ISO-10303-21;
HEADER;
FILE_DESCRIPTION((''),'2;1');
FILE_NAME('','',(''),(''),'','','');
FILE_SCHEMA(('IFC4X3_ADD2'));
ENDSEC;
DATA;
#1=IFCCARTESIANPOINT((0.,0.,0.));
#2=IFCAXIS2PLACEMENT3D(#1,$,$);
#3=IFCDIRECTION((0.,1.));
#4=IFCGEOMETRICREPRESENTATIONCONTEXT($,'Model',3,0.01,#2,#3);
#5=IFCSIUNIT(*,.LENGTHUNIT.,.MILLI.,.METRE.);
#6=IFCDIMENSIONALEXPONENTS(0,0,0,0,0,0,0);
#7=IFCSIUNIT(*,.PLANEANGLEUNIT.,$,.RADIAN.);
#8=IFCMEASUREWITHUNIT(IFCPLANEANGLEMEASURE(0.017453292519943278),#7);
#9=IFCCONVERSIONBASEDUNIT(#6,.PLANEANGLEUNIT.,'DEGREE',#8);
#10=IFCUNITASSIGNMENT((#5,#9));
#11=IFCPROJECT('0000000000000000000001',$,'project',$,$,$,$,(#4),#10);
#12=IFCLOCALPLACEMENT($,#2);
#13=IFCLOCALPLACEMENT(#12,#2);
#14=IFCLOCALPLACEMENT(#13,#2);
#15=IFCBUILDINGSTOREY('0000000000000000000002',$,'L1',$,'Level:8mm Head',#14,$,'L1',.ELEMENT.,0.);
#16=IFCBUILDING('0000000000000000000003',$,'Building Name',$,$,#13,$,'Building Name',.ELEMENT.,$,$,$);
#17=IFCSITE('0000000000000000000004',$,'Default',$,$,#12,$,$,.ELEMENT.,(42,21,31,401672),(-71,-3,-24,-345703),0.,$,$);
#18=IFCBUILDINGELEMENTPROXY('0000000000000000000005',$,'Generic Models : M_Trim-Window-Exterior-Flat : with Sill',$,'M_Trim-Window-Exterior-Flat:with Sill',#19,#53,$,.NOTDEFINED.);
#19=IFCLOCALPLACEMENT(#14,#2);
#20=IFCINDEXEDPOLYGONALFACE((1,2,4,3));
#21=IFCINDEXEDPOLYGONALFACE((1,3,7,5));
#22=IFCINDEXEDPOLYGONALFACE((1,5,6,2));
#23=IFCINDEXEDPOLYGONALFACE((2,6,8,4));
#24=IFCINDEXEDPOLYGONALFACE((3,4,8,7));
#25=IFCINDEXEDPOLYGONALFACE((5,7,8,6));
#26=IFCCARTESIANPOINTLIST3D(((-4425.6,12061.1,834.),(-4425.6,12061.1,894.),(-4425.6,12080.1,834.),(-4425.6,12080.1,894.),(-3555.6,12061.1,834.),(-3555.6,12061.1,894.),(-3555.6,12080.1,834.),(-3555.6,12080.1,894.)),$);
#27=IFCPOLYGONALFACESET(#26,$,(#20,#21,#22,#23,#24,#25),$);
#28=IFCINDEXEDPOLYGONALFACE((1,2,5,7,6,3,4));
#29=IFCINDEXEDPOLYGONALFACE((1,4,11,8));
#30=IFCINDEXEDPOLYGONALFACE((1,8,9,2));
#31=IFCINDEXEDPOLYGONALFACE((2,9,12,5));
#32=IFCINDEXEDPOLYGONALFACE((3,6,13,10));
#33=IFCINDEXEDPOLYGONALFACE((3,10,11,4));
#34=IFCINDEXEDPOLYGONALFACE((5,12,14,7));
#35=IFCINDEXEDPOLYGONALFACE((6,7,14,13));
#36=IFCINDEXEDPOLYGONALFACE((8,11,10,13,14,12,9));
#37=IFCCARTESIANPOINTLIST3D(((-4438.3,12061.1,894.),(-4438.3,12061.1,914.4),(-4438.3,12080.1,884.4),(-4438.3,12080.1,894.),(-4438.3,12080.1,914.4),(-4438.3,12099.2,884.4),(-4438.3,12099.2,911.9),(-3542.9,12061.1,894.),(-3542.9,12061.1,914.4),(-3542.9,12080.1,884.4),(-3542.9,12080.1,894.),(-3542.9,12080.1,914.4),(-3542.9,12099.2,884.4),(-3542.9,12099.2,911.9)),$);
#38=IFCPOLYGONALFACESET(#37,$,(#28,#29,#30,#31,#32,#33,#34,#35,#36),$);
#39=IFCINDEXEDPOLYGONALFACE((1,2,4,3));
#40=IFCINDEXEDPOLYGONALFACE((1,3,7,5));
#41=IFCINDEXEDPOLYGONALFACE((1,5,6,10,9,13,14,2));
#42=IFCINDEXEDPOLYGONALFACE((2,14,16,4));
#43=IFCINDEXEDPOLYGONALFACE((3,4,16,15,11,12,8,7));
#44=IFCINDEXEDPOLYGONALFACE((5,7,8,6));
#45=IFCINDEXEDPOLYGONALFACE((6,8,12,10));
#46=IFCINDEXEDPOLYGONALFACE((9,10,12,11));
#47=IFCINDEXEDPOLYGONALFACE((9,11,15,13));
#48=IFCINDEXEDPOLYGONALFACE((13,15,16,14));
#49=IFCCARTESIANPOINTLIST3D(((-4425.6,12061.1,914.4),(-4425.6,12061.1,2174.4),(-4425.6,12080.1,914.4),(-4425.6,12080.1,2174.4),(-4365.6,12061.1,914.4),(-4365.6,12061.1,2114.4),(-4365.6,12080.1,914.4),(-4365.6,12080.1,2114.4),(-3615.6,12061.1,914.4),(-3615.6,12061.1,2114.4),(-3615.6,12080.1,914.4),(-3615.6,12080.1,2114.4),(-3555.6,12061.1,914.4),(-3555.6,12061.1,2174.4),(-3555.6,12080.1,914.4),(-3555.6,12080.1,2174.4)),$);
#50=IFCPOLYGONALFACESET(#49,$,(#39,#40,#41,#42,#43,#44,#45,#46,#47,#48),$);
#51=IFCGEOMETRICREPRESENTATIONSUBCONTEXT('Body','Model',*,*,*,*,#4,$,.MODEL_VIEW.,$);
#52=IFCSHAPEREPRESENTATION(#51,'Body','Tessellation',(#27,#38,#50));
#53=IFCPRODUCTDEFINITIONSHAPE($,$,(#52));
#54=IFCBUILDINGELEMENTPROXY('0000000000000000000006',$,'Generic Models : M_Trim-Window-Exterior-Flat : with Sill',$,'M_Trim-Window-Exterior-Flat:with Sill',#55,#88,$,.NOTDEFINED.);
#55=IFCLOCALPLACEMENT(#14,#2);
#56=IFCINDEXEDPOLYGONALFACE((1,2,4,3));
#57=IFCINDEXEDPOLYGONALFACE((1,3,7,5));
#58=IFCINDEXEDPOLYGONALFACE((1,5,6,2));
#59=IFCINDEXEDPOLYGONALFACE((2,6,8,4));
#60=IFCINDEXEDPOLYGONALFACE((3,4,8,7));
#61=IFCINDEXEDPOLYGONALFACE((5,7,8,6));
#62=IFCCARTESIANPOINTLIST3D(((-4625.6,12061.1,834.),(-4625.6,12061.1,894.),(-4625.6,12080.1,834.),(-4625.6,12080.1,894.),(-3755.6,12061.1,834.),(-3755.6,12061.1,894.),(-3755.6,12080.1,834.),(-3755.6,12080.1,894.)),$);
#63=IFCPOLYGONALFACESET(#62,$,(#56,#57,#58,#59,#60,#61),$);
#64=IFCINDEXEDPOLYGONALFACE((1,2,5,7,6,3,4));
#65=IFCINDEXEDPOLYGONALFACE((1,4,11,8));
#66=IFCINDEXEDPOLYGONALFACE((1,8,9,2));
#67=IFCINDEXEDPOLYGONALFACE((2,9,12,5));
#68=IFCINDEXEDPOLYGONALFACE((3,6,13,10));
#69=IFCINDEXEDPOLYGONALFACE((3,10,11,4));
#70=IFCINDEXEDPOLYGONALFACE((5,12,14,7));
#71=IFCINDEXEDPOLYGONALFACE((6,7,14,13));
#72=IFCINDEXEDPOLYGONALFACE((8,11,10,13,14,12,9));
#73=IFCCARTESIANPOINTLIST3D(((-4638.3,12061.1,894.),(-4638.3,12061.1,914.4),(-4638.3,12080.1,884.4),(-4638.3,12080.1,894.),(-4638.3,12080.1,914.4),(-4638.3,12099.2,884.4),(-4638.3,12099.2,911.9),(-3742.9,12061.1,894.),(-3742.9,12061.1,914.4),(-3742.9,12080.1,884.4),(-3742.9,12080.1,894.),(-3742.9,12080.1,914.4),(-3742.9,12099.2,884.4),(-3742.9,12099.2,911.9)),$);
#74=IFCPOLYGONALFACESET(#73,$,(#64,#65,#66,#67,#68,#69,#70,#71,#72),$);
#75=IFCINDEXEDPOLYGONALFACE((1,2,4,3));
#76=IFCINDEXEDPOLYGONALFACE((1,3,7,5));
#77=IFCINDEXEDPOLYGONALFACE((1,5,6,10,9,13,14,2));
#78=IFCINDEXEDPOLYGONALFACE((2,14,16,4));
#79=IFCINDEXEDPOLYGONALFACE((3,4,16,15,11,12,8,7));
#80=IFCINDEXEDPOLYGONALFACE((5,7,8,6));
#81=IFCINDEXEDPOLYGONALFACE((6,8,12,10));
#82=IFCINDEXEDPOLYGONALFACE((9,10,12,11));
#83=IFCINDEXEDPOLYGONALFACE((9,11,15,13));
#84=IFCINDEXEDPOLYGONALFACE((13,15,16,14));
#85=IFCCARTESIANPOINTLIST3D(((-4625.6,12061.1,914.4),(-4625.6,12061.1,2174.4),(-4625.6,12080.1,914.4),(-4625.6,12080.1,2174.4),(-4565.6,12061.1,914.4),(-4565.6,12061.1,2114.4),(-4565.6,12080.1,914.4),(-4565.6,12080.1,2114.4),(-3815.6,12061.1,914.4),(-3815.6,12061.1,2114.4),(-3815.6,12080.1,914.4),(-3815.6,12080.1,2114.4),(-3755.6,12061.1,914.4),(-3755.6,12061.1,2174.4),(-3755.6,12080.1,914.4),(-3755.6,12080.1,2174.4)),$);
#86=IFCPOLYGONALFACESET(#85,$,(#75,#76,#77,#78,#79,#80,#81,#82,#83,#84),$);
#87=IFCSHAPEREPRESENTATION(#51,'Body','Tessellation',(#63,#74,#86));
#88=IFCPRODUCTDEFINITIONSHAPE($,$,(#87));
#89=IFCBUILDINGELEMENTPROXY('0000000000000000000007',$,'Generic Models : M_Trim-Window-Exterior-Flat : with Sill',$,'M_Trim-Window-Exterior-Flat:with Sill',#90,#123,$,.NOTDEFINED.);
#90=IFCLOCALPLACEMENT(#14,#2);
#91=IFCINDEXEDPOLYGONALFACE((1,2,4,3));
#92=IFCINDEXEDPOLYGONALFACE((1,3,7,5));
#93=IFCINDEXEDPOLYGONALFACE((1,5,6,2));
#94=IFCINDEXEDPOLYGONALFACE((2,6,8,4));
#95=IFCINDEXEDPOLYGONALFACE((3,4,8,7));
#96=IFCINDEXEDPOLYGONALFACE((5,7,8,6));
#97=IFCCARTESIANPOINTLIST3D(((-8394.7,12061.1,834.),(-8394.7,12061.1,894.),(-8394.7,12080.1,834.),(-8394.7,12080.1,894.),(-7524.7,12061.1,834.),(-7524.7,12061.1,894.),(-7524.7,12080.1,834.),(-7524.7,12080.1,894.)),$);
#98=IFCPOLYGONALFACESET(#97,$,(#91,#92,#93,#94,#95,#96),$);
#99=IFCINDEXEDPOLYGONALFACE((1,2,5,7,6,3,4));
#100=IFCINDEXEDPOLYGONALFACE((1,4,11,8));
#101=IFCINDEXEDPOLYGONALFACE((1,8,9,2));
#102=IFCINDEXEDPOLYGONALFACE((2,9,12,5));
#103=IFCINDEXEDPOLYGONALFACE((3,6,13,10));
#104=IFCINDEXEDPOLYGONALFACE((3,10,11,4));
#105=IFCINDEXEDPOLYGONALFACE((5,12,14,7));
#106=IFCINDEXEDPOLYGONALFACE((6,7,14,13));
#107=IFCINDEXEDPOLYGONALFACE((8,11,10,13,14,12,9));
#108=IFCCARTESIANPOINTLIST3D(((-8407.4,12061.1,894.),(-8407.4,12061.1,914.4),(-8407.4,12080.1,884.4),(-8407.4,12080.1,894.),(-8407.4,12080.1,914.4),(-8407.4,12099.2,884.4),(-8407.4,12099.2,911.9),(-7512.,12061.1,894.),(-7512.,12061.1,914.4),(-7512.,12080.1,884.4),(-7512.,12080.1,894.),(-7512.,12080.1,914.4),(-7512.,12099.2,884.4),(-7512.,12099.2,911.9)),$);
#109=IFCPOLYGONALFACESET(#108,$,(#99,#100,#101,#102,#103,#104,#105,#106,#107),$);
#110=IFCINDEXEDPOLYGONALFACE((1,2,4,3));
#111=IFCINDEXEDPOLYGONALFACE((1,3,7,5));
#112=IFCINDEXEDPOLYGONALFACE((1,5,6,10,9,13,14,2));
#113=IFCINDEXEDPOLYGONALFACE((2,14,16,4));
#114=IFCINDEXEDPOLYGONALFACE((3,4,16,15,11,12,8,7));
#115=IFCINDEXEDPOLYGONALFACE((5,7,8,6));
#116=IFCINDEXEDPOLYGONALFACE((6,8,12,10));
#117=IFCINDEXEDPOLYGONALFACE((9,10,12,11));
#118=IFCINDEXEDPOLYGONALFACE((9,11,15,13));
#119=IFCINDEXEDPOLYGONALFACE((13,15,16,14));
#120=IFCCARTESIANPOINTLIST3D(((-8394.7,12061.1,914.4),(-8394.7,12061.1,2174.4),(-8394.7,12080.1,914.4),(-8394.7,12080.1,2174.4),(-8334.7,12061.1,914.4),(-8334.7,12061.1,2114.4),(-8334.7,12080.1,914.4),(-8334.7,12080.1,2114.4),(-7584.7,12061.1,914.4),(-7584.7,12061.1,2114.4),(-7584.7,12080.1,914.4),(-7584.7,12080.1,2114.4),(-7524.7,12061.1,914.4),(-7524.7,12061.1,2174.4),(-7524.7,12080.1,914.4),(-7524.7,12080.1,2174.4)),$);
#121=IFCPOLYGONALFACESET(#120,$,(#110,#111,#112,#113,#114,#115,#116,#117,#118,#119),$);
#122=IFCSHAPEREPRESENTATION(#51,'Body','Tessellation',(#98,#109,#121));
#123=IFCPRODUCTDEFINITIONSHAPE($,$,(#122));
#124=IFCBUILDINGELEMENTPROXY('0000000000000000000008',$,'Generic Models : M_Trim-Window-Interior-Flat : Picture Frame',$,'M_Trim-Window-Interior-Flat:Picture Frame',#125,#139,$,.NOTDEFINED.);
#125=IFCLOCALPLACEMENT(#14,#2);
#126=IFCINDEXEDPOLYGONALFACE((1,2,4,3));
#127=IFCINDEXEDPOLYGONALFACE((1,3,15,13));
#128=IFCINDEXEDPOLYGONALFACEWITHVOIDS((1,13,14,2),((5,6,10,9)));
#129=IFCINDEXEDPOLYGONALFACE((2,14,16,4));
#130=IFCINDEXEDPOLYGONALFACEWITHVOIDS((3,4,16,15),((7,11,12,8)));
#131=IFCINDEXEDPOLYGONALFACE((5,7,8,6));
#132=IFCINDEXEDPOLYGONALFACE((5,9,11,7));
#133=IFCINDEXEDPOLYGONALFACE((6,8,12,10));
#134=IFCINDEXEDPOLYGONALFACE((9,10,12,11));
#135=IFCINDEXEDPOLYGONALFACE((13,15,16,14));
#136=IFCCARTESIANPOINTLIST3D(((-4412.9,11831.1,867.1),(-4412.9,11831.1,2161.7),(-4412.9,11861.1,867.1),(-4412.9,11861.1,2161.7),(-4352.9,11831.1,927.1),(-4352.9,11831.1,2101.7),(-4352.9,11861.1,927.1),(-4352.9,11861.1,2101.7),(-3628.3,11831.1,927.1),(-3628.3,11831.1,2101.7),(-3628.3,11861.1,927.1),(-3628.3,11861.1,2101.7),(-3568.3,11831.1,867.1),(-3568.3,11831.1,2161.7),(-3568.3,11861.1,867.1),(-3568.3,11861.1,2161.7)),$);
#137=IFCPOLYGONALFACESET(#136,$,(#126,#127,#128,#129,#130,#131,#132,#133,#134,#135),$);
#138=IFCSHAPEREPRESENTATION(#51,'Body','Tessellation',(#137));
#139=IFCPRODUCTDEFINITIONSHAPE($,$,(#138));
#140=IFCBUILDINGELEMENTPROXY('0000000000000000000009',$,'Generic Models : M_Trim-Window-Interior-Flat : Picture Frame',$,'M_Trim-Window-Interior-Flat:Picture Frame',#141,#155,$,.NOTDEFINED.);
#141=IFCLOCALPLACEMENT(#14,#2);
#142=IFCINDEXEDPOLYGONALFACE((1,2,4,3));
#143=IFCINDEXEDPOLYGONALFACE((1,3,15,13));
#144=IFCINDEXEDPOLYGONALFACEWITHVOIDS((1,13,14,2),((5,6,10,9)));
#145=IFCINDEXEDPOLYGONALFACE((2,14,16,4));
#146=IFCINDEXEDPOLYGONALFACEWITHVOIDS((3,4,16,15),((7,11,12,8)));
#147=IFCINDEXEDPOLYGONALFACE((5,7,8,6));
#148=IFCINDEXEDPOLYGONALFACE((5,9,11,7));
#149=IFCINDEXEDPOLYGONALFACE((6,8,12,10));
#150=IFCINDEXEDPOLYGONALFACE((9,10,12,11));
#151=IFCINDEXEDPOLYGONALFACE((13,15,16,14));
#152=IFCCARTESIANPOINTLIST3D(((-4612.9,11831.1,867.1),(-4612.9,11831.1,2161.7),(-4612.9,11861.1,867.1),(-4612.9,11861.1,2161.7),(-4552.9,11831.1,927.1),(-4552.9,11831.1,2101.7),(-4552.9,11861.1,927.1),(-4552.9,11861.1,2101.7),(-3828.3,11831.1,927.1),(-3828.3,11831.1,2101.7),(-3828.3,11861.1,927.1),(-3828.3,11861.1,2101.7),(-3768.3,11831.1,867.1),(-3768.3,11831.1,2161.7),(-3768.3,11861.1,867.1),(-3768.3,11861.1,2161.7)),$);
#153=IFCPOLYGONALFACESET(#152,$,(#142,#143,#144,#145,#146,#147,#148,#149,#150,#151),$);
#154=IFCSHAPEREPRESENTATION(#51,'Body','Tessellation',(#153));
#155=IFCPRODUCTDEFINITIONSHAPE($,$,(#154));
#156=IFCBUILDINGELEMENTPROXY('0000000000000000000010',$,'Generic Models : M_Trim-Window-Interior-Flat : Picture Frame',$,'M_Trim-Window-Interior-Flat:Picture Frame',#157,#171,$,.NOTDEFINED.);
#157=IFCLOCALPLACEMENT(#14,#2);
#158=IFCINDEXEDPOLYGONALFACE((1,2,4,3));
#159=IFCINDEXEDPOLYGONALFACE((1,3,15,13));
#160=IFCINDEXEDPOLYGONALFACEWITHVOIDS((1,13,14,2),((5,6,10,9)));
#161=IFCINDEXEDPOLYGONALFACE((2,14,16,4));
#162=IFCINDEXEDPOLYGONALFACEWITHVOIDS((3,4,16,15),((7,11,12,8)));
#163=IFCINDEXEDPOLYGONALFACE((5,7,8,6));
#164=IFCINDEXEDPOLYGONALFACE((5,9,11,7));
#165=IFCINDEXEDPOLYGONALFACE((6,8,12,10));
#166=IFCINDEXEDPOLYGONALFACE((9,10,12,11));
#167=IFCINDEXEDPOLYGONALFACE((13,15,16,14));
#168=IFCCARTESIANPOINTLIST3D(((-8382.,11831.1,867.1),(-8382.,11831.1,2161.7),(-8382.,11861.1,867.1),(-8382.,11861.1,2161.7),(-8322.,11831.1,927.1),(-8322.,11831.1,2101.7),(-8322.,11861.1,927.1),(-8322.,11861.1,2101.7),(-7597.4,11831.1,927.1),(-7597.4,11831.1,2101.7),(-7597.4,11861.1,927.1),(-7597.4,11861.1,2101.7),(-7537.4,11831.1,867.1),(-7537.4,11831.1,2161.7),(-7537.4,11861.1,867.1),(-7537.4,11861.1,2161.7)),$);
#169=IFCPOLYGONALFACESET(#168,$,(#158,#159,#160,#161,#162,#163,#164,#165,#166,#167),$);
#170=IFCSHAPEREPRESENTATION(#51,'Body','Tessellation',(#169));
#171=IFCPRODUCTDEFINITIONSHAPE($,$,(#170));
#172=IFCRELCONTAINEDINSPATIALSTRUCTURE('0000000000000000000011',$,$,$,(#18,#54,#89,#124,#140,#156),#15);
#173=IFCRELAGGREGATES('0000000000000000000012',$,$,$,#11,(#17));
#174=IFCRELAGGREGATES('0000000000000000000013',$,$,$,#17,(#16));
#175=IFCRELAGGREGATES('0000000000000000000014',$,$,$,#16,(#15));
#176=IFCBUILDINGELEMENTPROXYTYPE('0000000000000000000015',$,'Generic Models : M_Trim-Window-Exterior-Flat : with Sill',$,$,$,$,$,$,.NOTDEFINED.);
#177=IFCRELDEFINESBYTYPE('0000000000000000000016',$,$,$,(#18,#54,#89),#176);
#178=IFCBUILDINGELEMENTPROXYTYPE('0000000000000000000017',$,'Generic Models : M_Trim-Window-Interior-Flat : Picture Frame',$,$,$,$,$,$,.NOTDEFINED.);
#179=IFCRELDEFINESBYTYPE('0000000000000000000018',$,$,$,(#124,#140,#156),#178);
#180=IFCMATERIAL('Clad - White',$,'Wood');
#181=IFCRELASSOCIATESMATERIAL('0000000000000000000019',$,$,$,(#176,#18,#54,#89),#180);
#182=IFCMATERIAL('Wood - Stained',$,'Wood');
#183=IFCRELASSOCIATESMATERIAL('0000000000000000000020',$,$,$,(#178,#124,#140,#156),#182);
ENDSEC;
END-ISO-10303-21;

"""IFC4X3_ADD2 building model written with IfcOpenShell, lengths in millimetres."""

from ifc_helpers import new_model, entity, si_unit, converted_unit, direction, frame, frame_2d, origin, place, context, subcontext, project, spatial, polyline, rectangle, outline, extrude, source, transform, mapped, material, type_object, type_shapes, element, save


model = new_model("IFC4X3_ADD2")

# Units and contexts
model_context = context("Model", 3, precision=0.01, world=origin(), true_north=direction((0.0, 1.0)))
body_context = subcontext(model_context, "Body", "Model", "MODEL_VIEW")
ifc_project = project(units=[si_unit("LENGTHUNIT", "METRE", prefix="MILLI"), converted_unit("PLANEANGLEUNIT", "DEGREE", entity("IfcPlaneAngleMeasure", 0.017453292519943278), si_unit("PLANEANGLEUNIT", "RADIAN"), dimensions=[0, 0, 0, 0, 0, 0, 0])], contexts=[model_context])

# Site, building, storey
site_placement = place(None, origin())
site = spatial("IfcSite", under=ifc_project, at=site_placement, Name="Default", CompositionType="ELEMENT", RefLatitude=(42, 21, 31, 401672), RefLongitude=(-71, -3, -24, -345703), RefElevation=0.0)
building_placement = place(site_placement, origin())
building = spatial("IfcBuilding", under=site, at=building_placement, Name="Building Name", LongName="Building Name", CompositionType="ELEMENT")
storey_placement = place(building_placement, origin())
storey = spatial("IfcBuildingStorey", under=building, at=storey_placement, Name="L1", ObjectType="Level:8mm Head", LongName="L1", CompositionType="ELEMENT", Elevation=0.0)

# Shared definitions
ifc_material_1 = material(Name="Wood - Stained", Category="Wood")

# Building element proxies
ifc_material_2 = material(Name="Clad - White", Category="Wood")
building_element_proxy_type_1 = type_object("IfcBuildingElementProxyType", Name="Generic Models : M_Trim-Window-Exterior-Flat : with Sill", PredefinedType="NOTDEFINED", material=ifc_material_2)
shared_shape_1 = source(origin(), body_context, "Body", "SweptSolid", [
    extrude(rectangle(XDim=870.0, YDim=60.0, at=frame_2d((0.0, 0.0), x_axis=(1.0, 0.0))), frame((0.0, -1250.4, 0.0), z_axis=(0.0, 0.0, 1.0), x_axis=(-1.0, 0.0, 0.0)), (0.0, 0.0, 1.0), 19.0),
    extrude(outline(polyline([(-19.0, -15.2), (0.0, -15.2), (0.0, -5.7), (19.0, -5.7), (19.0, 14.8), (0.0, 14.8), (-19.0, 12.3), (-19.0, -15.2)])), frame((-447.7, -1214.8, 19.0), z_axis=(1.0, 0.0, 0.0), x_axis=(0.0, 0.0, -1.0)), (0.0, 0.0, 1.0), 895.4),
    extrude(outline(polyline([(-645.0, -435.0), (615.0, -435.0), (615.0, -375.0), (-585.0, -375.0), (-585.0, 375.0), (615.0, 375.0), (615.0, 435.0), (-645.0, 435.0), (-645.0, -435.0)])), frame((0.0, -585.0, 0.0), z_axis=(0.0, 0.0, 1.0), x_axis=(0.0, -1.0, 0.0)), (0.0, 0.0, 1.0), 19.0),
])
type_shapes(building_element_proxy_type_1, [shared_shape_1])
for number, where, z_axis, x_axis, name in (
    (1, (-3990.6, 12061.1, 2114.4), (0.0, 1.0, 0.0), (-1.0, 0.0, 0.0), "Generic Models : M_Trim-Window-Exterior-Flat : with Sill"),
    (2, (-4190.6, 12061.1, 2114.4), (0.0, 1.0, 0.0), (-1.0, 0.0, 0.0), "Generic Models : M_Trim-Window-Exterior-Flat : with Sill"),
    (3, (-7959.7, 12061.1, 2114.4), (0.0, 1.0, 0.0), (-1.0, 0.0, 0.0), "Generic Models : M_Trim-Window-Exterior-Flat : with Sill"),
):
    element("IfcBuildingElementProxy", number, at=place(storey_placement, frame(where, z_axis=z_axis, x_axis=x_axis)), inside=storey, type_object=building_element_proxy_type_1, material=ifc_material_2, Name=name, ObjectType="M_Trim-Window-Exterior-Flat:with Sill", PredefinedType="NOTDEFINED", context=body_context, shape_type="MappedRepresentation", body=[
        mapped(shared_shape_1, transform((0.0, 0.0, 0.0), scale=1.0)),
    ])
building_element_proxy_type_2 = type_object("IfcBuildingElementProxyType", Name="Generic Models : M_Trim-Window-Interior-Flat : Picture Frame", PredefinedType="NOTDEFINED", material=ifc_material_1)
shared_shape_2 = source(origin(), body_context, "Body", "SweptSolid", [
    extrude(outline(polyline([(-422.3, -647.3), (422.3, -647.3), (422.3, 647.3), (-422.3, 647.3), (-422.3, -647.3)]), holes=[polyline([(-362.3, -587.3), (-362.3, 587.3), (362.3, 587.3), (362.3, -587.3), (-362.3, -587.3)])]), frame((0.0, -600.0, 0.0), z_axis=(0.0, 0.0, 1.0), x_axis=(-1.0, 0.0, 0.0)), (0.0, 0.0, 1.0), 30.0),
])
type_shapes(building_element_proxy_type_2, [shared_shape_2])
for number, where, z_axis, x_axis, name in (
    (4, (-3990.6, 11861.1, 2114.4), (0.0, -1.0, 0.0), (1.0, 0.0, 0.0), "Generic Models : M_Trim-Window-Interior-Flat : Picture Frame"),
    (5, (-4190.6, 11861.1, 2114.4), (0.0, -1.0, 0.0), (1.0, 0.0, 0.0), "Generic Models : M_Trim-Window-Interior-Flat : Picture Frame"),
    (6, (-7959.7, 11861.1, 2114.4), (0.0, -1.0, 0.0), (1.0, 0.0, 0.0), "Generic Models : M_Trim-Window-Interior-Flat : Picture Frame"),
):
    element("IfcBuildingElementProxy", number, at=place(storey_placement, frame(where, z_axis=z_axis, x_axis=x_axis)), inside=storey, type_object=building_element_proxy_type_2, material=ifc_material_1, Name=name, ObjectType="M_Trim-Window-Interior-Flat:Picture Frame", PredefinedType="NOTDEFINED", context=body_context, shape_type="MappedRepresentation", body=[
        mapped(shared_shape_2, transform((0.0, 0.0, 0.0), scale=1.0)),
    ])

save(model, "model.ifc")
